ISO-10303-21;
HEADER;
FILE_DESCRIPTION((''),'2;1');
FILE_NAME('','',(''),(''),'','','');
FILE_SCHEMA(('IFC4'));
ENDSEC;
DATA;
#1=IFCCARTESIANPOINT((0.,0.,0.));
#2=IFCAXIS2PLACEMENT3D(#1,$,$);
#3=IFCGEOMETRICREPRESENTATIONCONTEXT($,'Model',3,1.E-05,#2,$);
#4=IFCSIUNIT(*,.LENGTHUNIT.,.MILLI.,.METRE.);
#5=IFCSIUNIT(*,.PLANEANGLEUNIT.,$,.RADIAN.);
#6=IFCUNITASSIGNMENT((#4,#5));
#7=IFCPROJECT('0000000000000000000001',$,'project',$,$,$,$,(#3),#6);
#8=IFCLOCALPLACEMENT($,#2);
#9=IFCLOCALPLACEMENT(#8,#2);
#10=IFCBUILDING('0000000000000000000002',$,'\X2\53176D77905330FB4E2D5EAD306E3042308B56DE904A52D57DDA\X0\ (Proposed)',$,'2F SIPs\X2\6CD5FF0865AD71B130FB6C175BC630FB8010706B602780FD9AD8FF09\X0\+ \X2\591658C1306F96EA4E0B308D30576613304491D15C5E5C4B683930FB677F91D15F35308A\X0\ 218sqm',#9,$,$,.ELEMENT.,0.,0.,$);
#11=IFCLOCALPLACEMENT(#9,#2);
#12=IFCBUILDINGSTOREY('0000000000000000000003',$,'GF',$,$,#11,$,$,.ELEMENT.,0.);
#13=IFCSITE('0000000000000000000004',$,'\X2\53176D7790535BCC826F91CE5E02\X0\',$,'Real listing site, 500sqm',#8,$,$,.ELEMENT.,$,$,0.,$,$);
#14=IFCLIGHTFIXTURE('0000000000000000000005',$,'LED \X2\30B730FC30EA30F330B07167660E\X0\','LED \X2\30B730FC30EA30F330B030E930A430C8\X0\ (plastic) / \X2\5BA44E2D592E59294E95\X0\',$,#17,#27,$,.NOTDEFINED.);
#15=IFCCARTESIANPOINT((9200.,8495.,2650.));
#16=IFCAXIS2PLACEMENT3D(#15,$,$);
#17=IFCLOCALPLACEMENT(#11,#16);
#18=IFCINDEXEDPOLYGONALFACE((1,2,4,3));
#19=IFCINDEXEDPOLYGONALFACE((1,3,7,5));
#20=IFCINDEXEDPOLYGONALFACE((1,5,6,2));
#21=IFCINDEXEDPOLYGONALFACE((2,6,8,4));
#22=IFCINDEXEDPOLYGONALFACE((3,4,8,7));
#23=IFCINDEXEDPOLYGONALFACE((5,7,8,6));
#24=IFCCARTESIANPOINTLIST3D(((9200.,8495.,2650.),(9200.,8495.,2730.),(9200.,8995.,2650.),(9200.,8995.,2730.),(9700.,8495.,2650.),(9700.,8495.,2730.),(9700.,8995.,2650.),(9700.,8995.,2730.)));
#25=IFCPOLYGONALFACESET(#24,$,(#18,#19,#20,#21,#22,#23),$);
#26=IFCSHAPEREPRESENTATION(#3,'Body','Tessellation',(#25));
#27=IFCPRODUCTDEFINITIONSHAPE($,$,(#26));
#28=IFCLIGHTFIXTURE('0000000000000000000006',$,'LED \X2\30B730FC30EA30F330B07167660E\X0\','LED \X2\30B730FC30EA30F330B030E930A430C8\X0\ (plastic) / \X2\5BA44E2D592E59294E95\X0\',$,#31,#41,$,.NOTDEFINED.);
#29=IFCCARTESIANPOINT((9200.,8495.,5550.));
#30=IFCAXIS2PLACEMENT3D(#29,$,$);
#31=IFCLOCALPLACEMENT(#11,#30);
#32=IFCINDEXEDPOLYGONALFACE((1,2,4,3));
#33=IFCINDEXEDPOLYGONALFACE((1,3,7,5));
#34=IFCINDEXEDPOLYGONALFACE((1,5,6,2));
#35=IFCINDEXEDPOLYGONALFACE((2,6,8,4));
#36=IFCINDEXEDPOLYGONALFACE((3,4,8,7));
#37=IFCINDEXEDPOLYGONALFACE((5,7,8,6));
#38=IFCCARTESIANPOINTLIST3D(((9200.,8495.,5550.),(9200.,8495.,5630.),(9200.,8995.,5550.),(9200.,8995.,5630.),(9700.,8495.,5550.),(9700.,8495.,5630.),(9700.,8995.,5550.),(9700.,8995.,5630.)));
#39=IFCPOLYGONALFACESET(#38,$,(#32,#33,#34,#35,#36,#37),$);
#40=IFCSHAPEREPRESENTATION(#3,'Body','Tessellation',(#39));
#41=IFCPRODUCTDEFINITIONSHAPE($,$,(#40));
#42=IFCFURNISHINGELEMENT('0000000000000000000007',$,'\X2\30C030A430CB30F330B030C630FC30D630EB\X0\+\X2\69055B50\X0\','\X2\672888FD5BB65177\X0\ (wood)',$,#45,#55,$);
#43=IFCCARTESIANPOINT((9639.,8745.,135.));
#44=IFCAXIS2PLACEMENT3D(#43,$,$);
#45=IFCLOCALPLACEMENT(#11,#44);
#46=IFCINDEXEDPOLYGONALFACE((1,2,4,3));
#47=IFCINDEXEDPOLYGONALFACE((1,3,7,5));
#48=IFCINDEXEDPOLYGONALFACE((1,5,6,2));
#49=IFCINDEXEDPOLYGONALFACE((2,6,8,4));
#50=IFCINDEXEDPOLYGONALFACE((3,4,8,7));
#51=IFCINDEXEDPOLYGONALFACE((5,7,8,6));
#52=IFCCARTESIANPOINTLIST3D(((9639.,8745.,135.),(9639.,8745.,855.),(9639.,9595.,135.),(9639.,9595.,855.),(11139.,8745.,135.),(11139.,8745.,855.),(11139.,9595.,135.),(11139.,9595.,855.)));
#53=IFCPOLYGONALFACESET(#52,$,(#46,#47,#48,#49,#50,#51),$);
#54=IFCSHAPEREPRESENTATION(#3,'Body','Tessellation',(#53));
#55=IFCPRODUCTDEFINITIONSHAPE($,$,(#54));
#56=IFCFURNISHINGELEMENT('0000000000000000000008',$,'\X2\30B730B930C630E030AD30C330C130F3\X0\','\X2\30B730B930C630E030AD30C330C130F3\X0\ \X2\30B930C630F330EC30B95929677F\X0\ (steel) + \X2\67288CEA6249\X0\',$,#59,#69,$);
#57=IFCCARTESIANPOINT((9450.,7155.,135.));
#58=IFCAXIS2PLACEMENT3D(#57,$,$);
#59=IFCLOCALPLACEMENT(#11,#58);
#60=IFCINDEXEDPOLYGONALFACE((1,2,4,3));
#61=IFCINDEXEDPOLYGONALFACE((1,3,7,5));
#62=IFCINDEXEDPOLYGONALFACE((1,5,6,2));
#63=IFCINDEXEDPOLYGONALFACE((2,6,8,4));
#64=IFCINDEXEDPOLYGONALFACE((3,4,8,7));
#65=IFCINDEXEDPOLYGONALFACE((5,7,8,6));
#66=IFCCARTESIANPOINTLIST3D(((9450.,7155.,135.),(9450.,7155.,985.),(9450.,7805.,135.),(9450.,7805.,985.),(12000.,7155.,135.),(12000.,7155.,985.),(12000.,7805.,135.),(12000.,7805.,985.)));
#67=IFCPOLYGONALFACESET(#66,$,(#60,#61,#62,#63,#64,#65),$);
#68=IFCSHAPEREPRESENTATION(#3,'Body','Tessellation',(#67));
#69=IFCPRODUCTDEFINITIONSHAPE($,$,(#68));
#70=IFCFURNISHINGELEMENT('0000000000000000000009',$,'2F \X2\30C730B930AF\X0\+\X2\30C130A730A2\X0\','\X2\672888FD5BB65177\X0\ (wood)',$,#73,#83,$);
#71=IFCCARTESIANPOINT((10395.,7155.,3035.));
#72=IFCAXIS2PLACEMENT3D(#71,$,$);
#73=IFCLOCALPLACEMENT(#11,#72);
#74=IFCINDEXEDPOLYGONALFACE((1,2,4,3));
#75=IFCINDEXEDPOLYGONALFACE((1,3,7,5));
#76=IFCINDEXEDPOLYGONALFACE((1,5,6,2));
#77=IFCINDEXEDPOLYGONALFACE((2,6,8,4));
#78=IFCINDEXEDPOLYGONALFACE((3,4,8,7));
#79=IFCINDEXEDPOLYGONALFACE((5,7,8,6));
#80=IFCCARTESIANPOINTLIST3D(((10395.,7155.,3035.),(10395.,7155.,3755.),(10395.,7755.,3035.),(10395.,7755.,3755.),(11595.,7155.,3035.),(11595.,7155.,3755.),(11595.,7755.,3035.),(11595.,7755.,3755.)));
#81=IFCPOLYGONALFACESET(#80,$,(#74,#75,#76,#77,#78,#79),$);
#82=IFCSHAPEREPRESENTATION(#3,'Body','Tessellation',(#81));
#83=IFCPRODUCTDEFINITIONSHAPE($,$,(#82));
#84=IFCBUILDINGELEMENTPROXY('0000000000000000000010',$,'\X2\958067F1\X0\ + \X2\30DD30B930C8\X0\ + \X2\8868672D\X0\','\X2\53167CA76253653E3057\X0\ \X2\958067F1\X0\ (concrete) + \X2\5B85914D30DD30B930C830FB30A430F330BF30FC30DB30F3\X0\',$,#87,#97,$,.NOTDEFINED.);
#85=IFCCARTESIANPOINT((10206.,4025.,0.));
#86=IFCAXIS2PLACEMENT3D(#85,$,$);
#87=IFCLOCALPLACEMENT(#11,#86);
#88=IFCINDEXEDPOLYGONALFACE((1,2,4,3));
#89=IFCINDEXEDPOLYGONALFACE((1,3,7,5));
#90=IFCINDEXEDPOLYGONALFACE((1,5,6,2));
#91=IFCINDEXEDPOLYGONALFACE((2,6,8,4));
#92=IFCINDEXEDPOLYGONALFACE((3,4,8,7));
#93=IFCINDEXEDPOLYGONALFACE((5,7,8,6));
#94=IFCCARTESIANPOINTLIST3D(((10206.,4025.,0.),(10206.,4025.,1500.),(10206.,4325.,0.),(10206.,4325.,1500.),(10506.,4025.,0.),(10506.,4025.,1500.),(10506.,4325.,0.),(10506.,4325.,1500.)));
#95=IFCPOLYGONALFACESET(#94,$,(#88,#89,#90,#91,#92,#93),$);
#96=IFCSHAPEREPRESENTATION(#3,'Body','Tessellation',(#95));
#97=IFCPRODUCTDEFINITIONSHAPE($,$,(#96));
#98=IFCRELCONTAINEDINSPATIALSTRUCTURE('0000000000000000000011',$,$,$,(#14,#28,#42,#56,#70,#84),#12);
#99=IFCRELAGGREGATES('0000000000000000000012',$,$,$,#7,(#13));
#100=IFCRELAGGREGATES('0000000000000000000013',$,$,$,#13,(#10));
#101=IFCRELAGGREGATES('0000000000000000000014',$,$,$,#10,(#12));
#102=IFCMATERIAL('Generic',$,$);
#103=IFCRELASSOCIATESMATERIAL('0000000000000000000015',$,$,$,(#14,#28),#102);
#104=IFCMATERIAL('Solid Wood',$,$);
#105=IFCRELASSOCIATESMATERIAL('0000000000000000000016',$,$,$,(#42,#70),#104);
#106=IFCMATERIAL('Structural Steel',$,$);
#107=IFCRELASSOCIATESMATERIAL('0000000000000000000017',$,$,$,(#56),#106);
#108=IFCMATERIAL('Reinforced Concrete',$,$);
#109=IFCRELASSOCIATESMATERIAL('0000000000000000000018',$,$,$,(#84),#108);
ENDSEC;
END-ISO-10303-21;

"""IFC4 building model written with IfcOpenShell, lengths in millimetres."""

from ifc_helpers import new_model, si_unit, frame, frame_2d, origin, place, context, project, spatial, rectangle, extrude, material, element, save


model = new_model("IFC4")

# Units and contexts
model_context = context("Model", 3, precision=1e-05, world=origin())
ifc_project = project(units=[si_unit("LENGTHUNIT", "METRE", prefix="MILLI"), si_unit("PLANEANGLEUNIT", "RADIAN")], contexts=[model_context])

# Site, building, storey
site_placement = place(None, origin())
site = spatial("IfcSite", under=ifc_project, at=site_placement, Name="北海道富良野市", ObjectType="Real listing site, 500sqm", CompositionType="ELEMENT", RefElevation=0.0)
building_placement = place(site_placement, origin())
building = spatial("IfcBuilding", under=site, at=building_placement, Name="北海道・中庭のある回遊動線 (Proposed)", ObjectType="2F SIPs法（断熱・気密・耐火性能高）+ 外壁は雪下ろし易い金属屋根・板金張り 218sqm", CompositionType="ELEMENT", ElevationOfRefHeight=0.0, ElevationOfTerrain=0.0)
storey_placement = place(building_placement, origin())
storey = spatial("IfcBuildingStorey", under=building, at=storey_placement, Name="GF", CompositionType="ELEMENT", Elevation=0.0)

# Shared definitions
ifc_material_1 = material(Name="Solid Wood")

# Shared definitions
ifc_material_2 = material(Name="Structural Steel")

# Shared definitions
ifc_material_3 = material(Name="Reinforced Concrete")

# Shared definitions
ifc_material_4 = material(Name="Generic")

# Light fixtures
light_fixture_1_placement = place(storey_placement, frame((9200.0, 8495.0, 2650.0)))
element("IfcLightFixture", 1, at=light_fixture_1_placement, inside=storey, material=ifc_material_4, Name="LED シーリング照明", Description="LED シーリングライト (plastic) / 室中央天井", PredefinedType="NOTDEFINED", context=model_context, shape_type="SweptSolid", body=[
    extrude(rectangle(XDim=500.0, YDim=500.0, at=frame_2d((250.0, 250.0))), frame((9200.0, 8495.0, 2650.0)), (0.0, 0.0, 1.0), 80.0),
])
light_fixture_2_placement = place(storey_placement, frame((9200.0, 8495.0, 5550.0)))
element("IfcLightFixture", 2, at=light_fixture_2_placement, inside=storey, material=ifc_material_4, Name="LED シーリング照明", Description="LED シーリングライト (plastic) / 室中央天井", PredefinedType="NOTDEFINED", context=model_context, shape_type="SweptSolid", body=[
    extrude(rectangle(XDim=500.0, YDim=500.0, at=frame_2d((250.0, 250.0))), frame((9200.0, 8495.0, 5550.0)), (0.0, 0.0, 1.0), 80.0),
])

# Furnishing elements
furnishing_1_placement = place(storey_placement, frame((9639.0, 8745.0, 135.0)))
element("IfcFurnishingElement", 3, at=furnishing_1_placement, inside=storey, material=ifc_material_1, Name="ダイニングテーブル+椅子", Description="木製家具 (wood)", context=model_context, shape_type="SweptSolid", body=[
    extrude(rectangle(XDim=1500.0, YDim=850.0, at=frame_2d((750.0, 425.0))), frame((9639.0, 8745.0, 135.0)), (0.0, 0.0, 1.0), 720.0),
])
furnishing_2_placement = place(storey_placement, frame((9450.0, 7155.0, 135.0)))
element("IfcFurnishingElement", 4, at=furnishing_2_placement, inside=storey, material=ifc_material_2, Name="システムキッチン", Description="システムキッチン ステンレス天板 (steel) + 木質扉", context=model_context, shape_type="SweptSolid", body=[
    extrude(rectangle(XDim=2550.0, YDim=650.0, at=frame_2d((1275.0, 325.0))), frame((9450.0, 7155.0, 135.0)), (0.0, 0.0, 1.0), 850.0),
])
furnishing_3_placement = place(storey_placement, frame((10395.0, 7155.0, 3035.0)))
element("IfcFurnishingElement", 5, at=furnishing_3_placement, inside=storey, material=ifc_material_1, Name="2F デスク+チェア", Description="木製家具 (wood)", context=model_context, shape_type="SweptSolid", body=[
    extrude(rectangle(XDim=1200.0, YDim=600.0, at=frame_2d((600.0, 300.0))), frame((10395.0, 7155.0, 3035.0)), (0.0, 0.0, 1.0), 720.0),
])

# Building element proxy
proxy_placement = place(storey_placement, frame((10206.0, 4025.0, 0.0)))
element("IfcBuildingElementProxy", 6, at=proxy_placement, inside=storey, material=ifc_material_3, Name="門柱 + ポスト + 表札", Description="化粧打放し 門柱 (concrete) + 宅配ポスト・インターホン", PredefinedType="NOTDEFINED", context=model_context, shape_type="SweptSolid", body=[
    extrude(rectangle(XDim=300.0, YDim=300.0, at=frame_2d((150.0, 150.0))), frame((10206.0, 4025.0, 0.0)), (0.0, 0.0, 1.0), 1500.0),
])

save(model, "model.ifc")
